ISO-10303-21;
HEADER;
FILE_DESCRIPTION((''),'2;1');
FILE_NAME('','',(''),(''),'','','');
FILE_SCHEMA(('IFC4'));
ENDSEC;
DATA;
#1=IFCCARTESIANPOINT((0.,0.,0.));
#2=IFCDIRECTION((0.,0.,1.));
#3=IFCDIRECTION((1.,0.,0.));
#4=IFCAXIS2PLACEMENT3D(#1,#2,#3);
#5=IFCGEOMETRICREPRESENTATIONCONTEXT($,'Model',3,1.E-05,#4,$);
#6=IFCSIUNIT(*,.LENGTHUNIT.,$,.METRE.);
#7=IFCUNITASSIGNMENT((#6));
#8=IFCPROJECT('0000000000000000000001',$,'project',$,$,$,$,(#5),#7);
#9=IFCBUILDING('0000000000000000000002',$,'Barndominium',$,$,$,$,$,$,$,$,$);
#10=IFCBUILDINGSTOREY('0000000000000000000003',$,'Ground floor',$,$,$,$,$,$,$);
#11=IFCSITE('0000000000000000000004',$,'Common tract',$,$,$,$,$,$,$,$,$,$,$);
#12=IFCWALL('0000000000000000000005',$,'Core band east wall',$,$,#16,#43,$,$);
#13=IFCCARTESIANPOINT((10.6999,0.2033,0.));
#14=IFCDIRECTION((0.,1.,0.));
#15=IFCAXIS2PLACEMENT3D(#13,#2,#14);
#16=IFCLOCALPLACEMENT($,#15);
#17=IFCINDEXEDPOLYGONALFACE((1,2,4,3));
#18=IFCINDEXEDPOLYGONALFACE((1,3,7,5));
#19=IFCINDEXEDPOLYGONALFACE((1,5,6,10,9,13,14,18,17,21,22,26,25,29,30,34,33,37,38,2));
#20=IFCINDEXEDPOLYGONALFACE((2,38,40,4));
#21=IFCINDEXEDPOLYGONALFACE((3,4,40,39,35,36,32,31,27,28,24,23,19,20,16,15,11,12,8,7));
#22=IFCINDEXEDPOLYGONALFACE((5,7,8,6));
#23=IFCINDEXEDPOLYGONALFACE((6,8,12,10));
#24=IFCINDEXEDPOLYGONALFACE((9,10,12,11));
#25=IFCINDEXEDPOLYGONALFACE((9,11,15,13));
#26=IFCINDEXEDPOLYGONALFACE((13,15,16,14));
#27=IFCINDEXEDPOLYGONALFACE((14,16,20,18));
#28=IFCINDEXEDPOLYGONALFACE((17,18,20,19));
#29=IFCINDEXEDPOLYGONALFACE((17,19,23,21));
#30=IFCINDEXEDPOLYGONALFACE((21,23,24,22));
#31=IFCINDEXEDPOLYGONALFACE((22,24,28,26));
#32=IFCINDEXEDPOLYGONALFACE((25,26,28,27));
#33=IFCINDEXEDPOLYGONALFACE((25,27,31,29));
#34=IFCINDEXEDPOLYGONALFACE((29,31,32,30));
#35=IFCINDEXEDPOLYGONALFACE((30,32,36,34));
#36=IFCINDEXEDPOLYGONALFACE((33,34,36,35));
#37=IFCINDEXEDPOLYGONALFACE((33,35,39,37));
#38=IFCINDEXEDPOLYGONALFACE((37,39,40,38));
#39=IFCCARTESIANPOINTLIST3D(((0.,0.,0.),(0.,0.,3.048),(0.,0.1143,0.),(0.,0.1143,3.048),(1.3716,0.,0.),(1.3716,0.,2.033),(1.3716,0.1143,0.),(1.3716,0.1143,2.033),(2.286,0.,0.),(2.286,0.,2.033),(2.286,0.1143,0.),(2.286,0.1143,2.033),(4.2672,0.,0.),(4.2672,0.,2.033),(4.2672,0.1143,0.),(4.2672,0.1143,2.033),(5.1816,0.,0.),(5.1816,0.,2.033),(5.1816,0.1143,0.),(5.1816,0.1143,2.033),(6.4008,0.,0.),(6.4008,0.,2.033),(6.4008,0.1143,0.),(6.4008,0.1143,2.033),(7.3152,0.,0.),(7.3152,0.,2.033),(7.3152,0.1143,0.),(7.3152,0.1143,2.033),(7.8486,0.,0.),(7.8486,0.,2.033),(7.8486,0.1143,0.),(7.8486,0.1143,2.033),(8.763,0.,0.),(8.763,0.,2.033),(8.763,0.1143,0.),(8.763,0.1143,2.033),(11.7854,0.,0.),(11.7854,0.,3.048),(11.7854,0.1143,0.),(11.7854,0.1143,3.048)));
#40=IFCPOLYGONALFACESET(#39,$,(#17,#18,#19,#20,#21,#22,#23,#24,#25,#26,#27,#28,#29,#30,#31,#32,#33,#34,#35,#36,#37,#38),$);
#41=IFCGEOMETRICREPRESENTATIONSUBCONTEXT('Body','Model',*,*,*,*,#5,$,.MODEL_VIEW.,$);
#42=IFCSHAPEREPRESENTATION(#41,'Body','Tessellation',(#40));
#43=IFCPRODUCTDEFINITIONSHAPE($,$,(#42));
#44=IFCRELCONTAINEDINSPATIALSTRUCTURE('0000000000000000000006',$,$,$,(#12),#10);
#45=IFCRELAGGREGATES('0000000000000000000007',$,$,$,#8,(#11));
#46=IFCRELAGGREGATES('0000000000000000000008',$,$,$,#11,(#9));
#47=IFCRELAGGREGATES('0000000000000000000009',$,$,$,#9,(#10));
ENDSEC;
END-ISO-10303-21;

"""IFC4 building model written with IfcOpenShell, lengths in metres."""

from ifc_helpers import new_model, si_unit, frame, origin_with_axes, place, context, subcontext, project, spatial, indexed_curve, rectangle, outline, extrude, element, save


model = new_model("IFC4")

# Units and contexts
model_context = context("Model", 3, precision=1e-05, world=origin_with_axes())
body_context = subcontext(model_context, "Body", "Model", "MODEL_VIEW")
ifc_project = project(units=[si_unit("LENGTHUNIT", "METRE")], contexts=[model_context])

# Site, building, storey
site = spatial("IfcSite", under=ifc_project, Name="Common tract")
building = spatial("IfcBuilding", under=site, Name="Barndominium")
storey = spatial("IfcBuildingStorey", under=building, Name="Ground floor")

# Wall, openings
wall_1_placement = place(None, frame((10.6999, 0.2033, 0.0), z_axis=(0.0, 0.0, 1.0), x_axis=(0.0, 1.0, 0.0)))
wall_1 = element("IfcWall", 1, at=wall_1_placement, inside=storey, Name="Core band east wall", context=body_context, shape_type="SweptSolid", body=[
    extrude(outline(indexed_curve([(0.0, 0.0), (0.0, 0.1143), (11.7854, 0.1143), (11.7854, 0.0), (0.0, 0.0)], self_intersect=False)), origin_with_axes(), (0.0, 0.0, 1.0), 3.048),
])
opening_1_placement = place(wall_1_placement, frame((1.8288, 0.0572, 0.0), z_axis=(0.0, 0.0, 1.0), x_axis=(0.0, -1.0, 0.0)))
element("IfcOpeningElement", 2, at=opening_1_placement, cuts=wall_1, context=body_context, shape_type="SweptSolid", body=[
    extrude(rectangle(XDim=0.3033, YDim=0.9144), origin_with_axes(), (0.0, 0.0, 1.0), 2.033),
])
opening_2_placement = place(wall_1_placement, frame((4.7244, 0.0572, 0.0), z_axis=(0.0, 0.0, 1.0), x_axis=(0.0, -1.0, 0.0)))
element("IfcOpeningElement", 3, at=opening_2_placement, cuts=wall_1, context=body_context, shape_type="SweptSolid", body=[
    extrude(rectangle(XDim=0.3033, YDim=0.9144), origin_with_axes(), (0.0, 0.0, 1.0), 2.033),
])
opening_3_placement = place(wall_1_placement, frame((6.858, 0.0572, 0.0), z_axis=(0.0, 0.0, 1.0), x_axis=(0.0, -1.0, 0.0)))
element("IfcOpeningElement", 4, at=opening_3_placement, cuts=wall_1, context=body_context, shape_type="SweptSolid", body=[
    extrude(rectangle(XDim=0.3033, YDim=0.9144), origin_with_axes(), (0.0, 0.0, 1.0), 2.033),
])
opening_4_placement = place(wall_1_placement, frame((8.3058, 0.0572, 0.0), z_axis=(0.0, 0.0, 1.0), x_axis=(0.0, -1.0, 0.0)))
element("IfcOpeningElement", 5, at=opening_4_placement, cuts=wall_1, context=body_context, shape_type="SweptSolid", body=[
    extrude(rectangle(XDim=0.3033, YDim=0.9144), origin_with_axes(), (0.0, 0.0, 1.0), 2.033),
])

save(model, "model.ifc")
